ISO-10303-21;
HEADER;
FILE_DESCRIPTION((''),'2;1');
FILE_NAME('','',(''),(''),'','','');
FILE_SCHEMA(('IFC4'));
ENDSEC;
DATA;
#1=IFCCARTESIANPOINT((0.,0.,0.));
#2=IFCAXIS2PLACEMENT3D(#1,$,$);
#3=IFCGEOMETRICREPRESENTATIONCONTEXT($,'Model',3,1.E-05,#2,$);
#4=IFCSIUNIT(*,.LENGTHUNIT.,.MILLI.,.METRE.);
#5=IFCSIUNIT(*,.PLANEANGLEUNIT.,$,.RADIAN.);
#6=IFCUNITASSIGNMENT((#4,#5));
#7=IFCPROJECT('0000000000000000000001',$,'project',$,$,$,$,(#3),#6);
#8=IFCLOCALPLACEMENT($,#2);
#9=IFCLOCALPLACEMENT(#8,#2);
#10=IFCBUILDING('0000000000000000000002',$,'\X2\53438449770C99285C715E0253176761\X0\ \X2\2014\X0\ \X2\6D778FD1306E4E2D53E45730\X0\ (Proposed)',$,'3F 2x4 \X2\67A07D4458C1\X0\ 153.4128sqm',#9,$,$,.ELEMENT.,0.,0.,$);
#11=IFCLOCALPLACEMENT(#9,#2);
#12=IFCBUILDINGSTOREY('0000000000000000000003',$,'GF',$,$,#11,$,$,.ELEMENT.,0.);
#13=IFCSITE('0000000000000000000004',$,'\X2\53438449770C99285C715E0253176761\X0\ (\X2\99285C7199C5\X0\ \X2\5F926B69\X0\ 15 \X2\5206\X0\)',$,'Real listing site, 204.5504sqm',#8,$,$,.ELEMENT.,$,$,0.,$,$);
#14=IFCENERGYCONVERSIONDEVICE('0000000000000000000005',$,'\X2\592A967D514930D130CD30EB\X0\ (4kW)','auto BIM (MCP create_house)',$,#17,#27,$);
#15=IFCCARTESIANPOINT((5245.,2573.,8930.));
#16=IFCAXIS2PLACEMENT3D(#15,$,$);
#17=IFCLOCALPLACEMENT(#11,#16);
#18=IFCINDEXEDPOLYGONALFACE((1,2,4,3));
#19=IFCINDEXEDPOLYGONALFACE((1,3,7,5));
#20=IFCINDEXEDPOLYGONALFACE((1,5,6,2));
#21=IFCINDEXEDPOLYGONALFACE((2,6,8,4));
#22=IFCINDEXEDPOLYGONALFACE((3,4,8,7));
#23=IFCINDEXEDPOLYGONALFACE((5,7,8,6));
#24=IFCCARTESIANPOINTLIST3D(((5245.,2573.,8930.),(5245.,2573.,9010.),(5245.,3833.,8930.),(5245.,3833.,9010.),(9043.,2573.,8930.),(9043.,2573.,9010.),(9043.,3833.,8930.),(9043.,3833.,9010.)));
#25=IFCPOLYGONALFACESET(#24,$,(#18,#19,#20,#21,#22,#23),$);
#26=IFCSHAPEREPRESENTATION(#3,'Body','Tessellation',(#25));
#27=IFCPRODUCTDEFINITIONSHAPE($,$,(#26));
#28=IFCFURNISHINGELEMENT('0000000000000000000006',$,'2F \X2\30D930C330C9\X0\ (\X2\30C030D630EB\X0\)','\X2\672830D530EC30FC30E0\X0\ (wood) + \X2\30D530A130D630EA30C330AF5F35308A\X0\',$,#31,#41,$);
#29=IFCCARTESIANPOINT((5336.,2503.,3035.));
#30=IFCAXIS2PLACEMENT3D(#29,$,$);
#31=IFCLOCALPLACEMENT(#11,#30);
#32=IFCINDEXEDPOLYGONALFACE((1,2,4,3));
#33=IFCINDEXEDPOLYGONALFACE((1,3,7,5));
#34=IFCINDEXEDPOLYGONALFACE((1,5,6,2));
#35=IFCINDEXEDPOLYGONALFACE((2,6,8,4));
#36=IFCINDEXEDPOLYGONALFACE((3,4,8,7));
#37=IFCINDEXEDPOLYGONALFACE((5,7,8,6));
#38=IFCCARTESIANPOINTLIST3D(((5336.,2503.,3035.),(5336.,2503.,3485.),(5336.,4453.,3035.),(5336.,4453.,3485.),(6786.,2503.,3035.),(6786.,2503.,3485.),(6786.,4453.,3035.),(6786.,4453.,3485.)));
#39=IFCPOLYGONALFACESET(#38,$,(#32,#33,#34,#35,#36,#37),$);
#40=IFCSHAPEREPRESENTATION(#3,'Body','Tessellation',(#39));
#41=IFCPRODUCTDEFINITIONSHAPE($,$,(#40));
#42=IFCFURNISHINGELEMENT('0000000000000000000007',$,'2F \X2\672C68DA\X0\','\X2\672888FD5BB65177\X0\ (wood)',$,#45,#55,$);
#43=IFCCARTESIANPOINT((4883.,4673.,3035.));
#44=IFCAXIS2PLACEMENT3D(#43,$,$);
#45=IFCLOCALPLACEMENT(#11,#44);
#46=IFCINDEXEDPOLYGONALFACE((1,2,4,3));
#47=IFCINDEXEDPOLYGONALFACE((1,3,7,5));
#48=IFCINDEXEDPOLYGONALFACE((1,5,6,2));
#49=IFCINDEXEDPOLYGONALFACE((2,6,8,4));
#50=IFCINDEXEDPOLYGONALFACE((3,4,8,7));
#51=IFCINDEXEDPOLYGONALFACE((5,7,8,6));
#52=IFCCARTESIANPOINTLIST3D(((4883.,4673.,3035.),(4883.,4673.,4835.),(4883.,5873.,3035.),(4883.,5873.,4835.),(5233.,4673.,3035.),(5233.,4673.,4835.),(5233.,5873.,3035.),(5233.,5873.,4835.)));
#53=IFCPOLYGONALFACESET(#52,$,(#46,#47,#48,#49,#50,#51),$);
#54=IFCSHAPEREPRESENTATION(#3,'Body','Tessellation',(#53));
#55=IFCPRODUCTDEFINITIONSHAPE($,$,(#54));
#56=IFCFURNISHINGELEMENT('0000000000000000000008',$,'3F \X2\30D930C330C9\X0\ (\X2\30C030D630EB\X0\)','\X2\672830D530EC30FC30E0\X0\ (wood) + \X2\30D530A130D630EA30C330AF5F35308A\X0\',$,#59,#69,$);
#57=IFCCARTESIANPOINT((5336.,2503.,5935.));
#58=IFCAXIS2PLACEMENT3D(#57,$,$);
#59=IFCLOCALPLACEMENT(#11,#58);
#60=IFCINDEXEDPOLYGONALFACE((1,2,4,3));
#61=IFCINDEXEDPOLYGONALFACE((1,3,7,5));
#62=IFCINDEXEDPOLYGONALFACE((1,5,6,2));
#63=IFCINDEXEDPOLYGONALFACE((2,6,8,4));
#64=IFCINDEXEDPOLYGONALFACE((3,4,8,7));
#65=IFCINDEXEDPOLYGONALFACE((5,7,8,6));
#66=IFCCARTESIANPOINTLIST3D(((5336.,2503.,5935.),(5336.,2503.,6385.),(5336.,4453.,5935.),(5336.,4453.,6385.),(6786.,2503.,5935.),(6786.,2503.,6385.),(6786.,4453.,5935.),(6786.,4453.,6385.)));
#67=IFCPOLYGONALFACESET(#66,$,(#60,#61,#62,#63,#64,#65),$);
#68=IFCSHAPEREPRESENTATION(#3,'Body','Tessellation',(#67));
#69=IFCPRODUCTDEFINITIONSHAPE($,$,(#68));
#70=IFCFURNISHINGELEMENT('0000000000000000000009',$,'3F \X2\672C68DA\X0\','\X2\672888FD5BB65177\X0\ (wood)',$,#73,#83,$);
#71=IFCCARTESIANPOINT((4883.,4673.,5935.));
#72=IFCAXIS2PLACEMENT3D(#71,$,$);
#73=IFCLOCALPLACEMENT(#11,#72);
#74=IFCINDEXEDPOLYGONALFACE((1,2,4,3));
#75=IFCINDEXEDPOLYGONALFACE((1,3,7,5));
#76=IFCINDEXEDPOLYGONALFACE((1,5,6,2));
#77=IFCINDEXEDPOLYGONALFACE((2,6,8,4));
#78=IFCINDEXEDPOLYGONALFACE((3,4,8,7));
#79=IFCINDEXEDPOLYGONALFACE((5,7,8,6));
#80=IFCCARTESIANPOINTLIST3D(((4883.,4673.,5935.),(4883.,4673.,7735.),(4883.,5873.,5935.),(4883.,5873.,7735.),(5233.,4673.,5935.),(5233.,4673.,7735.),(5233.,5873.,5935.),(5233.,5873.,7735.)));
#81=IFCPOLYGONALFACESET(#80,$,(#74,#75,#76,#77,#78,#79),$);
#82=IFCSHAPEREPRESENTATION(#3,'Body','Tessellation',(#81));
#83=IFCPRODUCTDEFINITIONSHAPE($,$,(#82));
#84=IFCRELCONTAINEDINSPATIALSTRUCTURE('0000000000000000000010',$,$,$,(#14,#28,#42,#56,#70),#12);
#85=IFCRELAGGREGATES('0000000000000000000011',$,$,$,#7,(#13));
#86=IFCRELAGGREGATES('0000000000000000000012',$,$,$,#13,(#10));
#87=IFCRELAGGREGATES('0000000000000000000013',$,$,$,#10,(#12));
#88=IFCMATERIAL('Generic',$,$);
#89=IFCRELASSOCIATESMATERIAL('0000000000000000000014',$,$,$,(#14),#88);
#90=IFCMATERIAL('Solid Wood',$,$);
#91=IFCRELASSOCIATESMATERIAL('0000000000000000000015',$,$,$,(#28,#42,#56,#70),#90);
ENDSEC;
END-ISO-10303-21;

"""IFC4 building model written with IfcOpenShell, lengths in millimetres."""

from ifc_helpers import new_model, si_unit, frame, frame_2d, origin, place, context, project, spatial, rectangle, extrude, material, element, save


model = new_model("IFC4")

# Units and contexts
model_context = context("Model", 3, precision=1e-05, world=origin())
ifc_project = project(units=[si_unit("LENGTHUNIT", "METRE", prefix="MILLI"), si_unit("PLANEANGLEUNIT", "RADIAN")], contexts=[model_context])

# Site, building, storey
site_placement = place(None, origin())
site = spatial("IfcSite", under=ifc_project, at=site_placement, Name="千葉県館山市北条 (館山駅 徒歩 15 分)", ObjectType="Real listing site, 204.5504sqm", CompositionType="ELEMENT", RefElevation=0.0)
building_placement = place(site_placement, origin())
building = spatial("IfcBuilding", under=site, at=building_placement, Name="千葉県館山市北条 — 海近の中古地 (Proposed)", ObjectType="3F 2x4 枠組壁 153.4128sqm", CompositionType="ELEMENT", ElevationOfRefHeight=0.0, ElevationOfTerrain=0.0)
storey_placement = place(building_placement, origin())
storey = spatial("IfcBuildingStorey", under=building, at=storey_placement, Name="GF", CompositionType="ELEMENT", Elevation=0.0)

# Shared definitions
ifc_material_1 = material(Name="Solid Wood")

# Shared definitions
ifc_material_2 = material(Name="Generic")

# Energy conversion device
energy_conversion_device_placement = place(storey_placement, frame((5245.0, 2573.0, 8930.0)))
element("IfcEnergyConversionDevice", 1, at=energy_conversion_device_placement, inside=storey, material=ifc_material_2, Name="太陽光パネル (4kW)", Description="auto BIM (MCP create_house)", context=model_context, shape_type="SweptSolid", body=[
    extrude(rectangle(XDim=3798.0, YDim=1260.0, at=frame_2d((1899.0, 630.0))), frame((5245.0, 2573.0, 8930.0)), (0.0, 0.0, 1.0), 80.0),
])

# Furnishing elements
furnishing_1_placement = place(storey_placement, frame((5336.0, 2503.0, 3035.0)))
element("IfcFurnishingElement", 2, at=furnishing_1_placement, inside=storey, material=ifc_material_1, Name="2F ベッド (ダブル)", Description="木フレーム (wood) + ファブリック張り", context=model_context, shape_type="SweptSolid", body=[
    extrude(rectangle(XDim=1450.0, YDim=1950.0, at=frame_2d((725.0, 975.0))), frame((5336.0, 2503.0, 3035.0)), (0.0, 0.0, 1.0), 450.0),
])
furnishing_2_placement = place(storey_placement, frame((4883.0, 4673.0, 3035.0)))
element("IfcFurnishingElement", 3, at=furnishing_2_placement, inside=storey, material=ifc_material_1, Name="2F 本棚", Description="木製家具 (wood)", context=model_context, shape_type="SweptSolid", body=[
    extrude(rectangle(XDim=350.0, YDim=1200.0, at=frame_2d((175.0, 600.0))), frame((4883.0, 4673.0, 3035.0)), (0.0, 0.0, 1.0), 1800.0),
])
furnishing_3_placement = place(storey_placement, frame((5336.0, 2503.0, 5935.0)))
element("IfcFurnishingElement", 4, at=furnishing_3_placement, inside=storey, material=ifc_material_1, Name="3F ベッド (ダブル)", Description="木フレーム (wood) + ファブリック張り", context=model_context, shape_type="SweptSolid", body=[
    extrude(rectangle(XDim=1450.0, YDim=1950.0, at=frame_2d((725.0, 975.0))), frame((5336.0, 2503.0, 5935.0)), (0.0, 0.0, 1.0), 450.0),
])
furnishing_4_placement = place(storey_placement, frame((4883.0, 4673.0, 5935.0)))
element("IfcFurnishingElement", 5, at=furnishing_4_placement, inside=storey, material=ifc_material_1, Name="3F 本棚", Description="木製家具 (wood)", context=model_context, shape_type="SweptSolid", body=[
    extrude(rectangle(XDim=350.0, YDim=1200.0, at=frame_2d((175.0, 600.0))), frame((4883.0, 4673.0, 5935.0)), (0.0, 0.0, 1.0), 1800.0),
])

save(model, "model.ifc")
